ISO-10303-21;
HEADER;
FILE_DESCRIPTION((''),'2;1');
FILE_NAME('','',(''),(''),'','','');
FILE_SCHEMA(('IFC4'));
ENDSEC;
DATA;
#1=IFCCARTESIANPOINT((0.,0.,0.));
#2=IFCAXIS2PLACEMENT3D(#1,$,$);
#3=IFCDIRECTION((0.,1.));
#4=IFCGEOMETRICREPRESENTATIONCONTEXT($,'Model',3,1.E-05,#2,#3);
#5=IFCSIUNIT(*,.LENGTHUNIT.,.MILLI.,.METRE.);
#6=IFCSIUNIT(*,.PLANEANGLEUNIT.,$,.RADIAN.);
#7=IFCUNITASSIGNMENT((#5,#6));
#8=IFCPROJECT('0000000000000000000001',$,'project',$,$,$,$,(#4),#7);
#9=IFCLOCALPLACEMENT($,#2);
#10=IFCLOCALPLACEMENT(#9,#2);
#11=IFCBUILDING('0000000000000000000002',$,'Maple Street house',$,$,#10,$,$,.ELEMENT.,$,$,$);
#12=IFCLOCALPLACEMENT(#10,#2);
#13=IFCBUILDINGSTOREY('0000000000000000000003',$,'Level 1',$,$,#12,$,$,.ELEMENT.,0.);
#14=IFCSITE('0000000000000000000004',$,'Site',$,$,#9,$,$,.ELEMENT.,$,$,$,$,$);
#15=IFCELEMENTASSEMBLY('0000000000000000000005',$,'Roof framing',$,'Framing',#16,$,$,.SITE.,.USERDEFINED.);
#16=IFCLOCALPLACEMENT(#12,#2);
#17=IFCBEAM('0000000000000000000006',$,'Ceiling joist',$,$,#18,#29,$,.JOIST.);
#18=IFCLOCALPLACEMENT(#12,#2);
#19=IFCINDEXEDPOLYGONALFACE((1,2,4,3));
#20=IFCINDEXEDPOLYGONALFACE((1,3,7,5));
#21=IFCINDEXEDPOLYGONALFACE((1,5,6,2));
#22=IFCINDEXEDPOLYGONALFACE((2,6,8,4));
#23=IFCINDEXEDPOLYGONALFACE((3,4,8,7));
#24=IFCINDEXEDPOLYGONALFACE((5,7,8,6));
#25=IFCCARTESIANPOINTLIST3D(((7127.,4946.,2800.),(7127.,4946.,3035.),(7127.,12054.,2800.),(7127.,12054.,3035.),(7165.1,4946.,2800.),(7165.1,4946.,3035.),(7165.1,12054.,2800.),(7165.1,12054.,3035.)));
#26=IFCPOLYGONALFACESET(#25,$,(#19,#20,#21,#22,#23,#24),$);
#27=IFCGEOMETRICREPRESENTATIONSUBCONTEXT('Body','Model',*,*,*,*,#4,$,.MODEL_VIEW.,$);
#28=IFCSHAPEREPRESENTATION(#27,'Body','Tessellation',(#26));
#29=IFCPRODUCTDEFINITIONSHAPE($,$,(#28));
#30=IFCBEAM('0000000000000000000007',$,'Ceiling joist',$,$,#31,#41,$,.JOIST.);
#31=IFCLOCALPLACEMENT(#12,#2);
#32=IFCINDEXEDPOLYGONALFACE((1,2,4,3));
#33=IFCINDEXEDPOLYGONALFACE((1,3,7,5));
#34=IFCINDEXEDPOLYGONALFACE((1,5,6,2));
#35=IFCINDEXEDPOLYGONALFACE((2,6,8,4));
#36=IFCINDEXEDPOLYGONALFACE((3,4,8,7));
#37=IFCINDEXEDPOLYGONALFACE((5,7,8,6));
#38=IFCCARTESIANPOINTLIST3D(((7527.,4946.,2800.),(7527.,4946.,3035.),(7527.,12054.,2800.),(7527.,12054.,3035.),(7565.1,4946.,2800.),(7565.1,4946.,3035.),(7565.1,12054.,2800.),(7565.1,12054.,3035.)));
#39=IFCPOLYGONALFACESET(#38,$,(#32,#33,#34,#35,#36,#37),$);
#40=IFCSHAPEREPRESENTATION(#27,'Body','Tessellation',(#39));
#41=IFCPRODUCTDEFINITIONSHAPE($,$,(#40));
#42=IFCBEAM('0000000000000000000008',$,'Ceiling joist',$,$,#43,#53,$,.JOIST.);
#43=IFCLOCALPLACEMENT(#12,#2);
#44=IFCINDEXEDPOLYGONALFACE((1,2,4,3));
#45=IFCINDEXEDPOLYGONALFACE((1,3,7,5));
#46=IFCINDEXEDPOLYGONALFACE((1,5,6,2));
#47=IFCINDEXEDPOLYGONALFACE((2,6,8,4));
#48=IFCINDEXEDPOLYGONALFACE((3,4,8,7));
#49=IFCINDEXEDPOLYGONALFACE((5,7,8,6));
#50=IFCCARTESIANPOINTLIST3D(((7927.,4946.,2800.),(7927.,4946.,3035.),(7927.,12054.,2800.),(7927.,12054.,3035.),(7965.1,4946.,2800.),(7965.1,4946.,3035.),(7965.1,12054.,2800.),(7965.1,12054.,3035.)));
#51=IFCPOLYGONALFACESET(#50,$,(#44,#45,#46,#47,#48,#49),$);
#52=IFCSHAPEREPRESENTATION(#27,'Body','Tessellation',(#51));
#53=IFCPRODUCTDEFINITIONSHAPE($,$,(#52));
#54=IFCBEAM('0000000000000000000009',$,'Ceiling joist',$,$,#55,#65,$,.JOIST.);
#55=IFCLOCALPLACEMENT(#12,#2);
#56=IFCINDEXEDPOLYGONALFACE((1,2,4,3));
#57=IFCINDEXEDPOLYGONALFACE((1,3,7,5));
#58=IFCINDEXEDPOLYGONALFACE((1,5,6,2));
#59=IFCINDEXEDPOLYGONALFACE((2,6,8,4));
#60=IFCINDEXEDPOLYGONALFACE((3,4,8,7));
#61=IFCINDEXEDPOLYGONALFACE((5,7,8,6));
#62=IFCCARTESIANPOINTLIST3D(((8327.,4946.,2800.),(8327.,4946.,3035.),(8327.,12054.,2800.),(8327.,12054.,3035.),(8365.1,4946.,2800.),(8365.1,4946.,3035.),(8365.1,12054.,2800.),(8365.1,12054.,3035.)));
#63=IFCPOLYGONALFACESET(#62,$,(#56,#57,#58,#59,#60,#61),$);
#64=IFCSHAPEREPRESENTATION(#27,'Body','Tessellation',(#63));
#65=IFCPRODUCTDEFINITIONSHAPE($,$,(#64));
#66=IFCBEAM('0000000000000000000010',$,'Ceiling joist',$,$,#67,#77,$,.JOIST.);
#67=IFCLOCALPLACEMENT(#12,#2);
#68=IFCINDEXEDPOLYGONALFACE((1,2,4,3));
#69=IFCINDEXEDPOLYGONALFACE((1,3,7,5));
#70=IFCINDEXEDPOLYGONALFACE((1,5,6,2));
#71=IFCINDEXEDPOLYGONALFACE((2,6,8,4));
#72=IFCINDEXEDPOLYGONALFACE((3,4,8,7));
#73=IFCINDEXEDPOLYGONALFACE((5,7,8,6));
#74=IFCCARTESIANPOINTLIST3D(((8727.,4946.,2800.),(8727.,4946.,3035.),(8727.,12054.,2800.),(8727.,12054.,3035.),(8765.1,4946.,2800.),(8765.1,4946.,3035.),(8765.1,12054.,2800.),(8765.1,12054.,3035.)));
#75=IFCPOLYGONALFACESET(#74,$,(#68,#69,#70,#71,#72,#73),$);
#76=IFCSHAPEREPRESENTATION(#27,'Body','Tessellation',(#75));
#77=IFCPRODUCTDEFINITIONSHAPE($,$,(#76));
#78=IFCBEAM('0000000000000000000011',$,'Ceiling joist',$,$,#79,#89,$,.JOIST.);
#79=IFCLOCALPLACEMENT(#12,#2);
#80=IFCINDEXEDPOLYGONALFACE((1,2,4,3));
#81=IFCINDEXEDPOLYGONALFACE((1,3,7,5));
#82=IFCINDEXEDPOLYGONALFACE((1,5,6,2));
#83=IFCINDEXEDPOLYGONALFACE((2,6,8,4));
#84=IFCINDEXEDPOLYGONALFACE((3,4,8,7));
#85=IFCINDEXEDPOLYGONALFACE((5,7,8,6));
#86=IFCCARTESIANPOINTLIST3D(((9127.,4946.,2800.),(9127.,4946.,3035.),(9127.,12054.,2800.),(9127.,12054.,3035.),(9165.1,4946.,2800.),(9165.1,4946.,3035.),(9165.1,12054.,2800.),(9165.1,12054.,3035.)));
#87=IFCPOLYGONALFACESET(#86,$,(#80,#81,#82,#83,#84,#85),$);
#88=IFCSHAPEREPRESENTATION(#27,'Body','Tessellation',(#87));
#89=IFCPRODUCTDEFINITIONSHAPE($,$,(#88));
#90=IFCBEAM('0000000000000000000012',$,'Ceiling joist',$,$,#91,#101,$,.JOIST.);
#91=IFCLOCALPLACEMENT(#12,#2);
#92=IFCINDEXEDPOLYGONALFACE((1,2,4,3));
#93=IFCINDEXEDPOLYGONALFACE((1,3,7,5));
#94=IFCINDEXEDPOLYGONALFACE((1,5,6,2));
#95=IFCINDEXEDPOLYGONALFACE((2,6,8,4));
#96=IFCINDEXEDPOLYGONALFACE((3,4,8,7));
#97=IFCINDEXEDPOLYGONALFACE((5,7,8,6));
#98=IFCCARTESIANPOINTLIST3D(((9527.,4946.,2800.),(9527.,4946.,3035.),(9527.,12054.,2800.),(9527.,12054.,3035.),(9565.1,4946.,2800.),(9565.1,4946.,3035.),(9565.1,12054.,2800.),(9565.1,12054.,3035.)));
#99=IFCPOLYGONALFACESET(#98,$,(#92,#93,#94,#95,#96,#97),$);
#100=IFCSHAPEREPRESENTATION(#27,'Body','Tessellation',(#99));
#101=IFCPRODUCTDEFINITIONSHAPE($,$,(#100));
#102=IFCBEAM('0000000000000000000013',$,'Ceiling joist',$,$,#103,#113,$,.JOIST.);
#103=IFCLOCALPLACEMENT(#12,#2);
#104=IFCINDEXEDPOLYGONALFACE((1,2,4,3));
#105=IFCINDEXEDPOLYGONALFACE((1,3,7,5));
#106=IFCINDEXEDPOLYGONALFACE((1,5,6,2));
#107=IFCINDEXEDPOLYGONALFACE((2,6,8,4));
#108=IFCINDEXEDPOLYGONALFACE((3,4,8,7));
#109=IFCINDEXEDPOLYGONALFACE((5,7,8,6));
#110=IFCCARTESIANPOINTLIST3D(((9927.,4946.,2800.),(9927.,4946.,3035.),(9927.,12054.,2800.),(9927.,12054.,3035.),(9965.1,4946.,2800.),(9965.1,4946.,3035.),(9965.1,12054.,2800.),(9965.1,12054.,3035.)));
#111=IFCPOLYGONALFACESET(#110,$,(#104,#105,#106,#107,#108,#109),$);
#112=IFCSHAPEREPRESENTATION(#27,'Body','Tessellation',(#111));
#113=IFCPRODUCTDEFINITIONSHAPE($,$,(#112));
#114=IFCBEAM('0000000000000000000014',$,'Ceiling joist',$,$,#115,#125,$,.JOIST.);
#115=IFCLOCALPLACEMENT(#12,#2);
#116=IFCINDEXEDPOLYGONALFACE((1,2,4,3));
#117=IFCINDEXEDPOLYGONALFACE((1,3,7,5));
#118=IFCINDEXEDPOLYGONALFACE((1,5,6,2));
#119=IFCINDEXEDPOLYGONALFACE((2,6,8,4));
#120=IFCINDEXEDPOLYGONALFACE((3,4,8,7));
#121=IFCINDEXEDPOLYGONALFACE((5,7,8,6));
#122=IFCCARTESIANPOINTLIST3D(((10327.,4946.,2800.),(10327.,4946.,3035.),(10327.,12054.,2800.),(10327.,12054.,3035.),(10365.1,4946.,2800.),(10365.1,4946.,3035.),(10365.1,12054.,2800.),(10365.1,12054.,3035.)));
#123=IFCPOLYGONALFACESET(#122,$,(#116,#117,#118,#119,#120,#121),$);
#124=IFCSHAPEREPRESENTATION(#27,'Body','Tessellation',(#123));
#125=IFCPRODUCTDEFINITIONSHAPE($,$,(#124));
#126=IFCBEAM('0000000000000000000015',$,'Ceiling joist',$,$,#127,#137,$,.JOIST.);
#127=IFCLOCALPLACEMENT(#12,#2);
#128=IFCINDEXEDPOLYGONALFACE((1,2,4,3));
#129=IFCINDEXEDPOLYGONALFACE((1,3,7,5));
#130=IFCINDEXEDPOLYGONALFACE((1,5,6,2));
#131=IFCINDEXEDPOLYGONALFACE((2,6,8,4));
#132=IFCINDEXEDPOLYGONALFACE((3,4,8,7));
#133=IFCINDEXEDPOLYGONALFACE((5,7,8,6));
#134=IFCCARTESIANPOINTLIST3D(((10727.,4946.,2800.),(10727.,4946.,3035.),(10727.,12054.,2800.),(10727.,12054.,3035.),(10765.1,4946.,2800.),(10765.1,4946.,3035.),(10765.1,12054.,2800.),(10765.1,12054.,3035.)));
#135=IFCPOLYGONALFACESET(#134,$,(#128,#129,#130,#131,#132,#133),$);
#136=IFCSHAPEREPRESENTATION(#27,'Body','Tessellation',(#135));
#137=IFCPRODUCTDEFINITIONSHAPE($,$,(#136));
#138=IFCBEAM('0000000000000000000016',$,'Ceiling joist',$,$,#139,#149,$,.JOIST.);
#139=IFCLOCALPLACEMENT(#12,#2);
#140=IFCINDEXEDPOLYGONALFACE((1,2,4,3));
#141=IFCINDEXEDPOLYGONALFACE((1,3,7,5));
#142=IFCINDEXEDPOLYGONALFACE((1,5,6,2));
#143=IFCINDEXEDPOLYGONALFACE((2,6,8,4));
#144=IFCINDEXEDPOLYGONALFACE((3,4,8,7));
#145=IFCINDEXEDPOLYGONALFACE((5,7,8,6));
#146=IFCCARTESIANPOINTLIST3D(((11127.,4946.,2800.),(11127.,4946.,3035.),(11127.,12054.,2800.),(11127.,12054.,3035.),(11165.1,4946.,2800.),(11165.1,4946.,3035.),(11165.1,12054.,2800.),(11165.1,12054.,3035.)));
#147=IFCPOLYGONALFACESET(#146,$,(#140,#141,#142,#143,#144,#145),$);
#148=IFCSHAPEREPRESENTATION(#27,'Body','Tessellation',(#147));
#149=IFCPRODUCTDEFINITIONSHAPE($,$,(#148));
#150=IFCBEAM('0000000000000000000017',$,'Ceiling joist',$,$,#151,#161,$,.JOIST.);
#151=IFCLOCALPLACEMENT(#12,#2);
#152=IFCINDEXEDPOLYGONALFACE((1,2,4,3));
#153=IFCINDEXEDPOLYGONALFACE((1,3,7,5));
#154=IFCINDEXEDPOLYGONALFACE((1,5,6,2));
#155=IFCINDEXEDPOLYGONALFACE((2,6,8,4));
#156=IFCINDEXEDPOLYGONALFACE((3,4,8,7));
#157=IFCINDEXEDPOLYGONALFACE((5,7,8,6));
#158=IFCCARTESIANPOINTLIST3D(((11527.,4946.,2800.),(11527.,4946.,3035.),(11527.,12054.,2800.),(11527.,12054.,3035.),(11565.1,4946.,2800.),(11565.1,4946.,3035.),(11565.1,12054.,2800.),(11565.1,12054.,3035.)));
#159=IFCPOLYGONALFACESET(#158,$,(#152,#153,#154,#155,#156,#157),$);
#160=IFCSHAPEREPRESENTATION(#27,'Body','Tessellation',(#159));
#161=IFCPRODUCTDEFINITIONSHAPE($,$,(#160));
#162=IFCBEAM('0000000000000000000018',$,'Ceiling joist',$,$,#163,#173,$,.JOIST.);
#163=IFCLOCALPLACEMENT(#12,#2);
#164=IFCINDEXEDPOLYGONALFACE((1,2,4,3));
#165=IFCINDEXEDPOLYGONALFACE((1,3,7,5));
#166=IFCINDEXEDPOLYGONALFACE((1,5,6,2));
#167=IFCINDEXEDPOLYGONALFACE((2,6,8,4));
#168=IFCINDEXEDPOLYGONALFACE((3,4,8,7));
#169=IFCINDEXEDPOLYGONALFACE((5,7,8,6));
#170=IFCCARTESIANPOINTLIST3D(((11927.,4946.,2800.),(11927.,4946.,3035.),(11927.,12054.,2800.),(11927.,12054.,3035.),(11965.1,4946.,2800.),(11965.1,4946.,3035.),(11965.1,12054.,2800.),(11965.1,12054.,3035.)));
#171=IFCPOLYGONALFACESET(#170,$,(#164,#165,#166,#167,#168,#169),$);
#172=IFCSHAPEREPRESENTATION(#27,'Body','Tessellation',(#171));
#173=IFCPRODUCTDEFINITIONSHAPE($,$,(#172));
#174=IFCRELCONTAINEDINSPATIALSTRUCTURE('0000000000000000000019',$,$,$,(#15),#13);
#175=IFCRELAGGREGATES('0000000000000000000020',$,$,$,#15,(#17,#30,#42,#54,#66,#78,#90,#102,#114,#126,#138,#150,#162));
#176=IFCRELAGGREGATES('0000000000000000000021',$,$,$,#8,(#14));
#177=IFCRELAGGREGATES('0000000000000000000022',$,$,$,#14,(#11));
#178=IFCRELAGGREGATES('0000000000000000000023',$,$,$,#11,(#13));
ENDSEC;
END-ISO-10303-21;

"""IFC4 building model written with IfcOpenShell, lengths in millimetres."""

from ifc_helpers import new_model, si_unit, direction, frame, origin, origin_with_axes, place, context, subcontext, project, spatial, polyline, outline, extrude, element, aggregate, save


model = new_model("IFC4")

# Units and contexts
model_context = context("Model", 3, precision=1e-05, world=origin(), true_north=direction((0.0, 1.0)))
body_context = subcontext(model_context, "Body", "Model", "MODEL_VIEW")
ifc_project = project(units=[si_unit("LENGTHUNIT", "METRE", prefix="MILLI"), si_unit("PLANEANGLEUNIT", "RADIAN")], contexts=[model_context])

# Site, building, storey
site_placement = place(None, origin())
site = spatial("IfcSite", under=ifc_project, at=site_placement, Name="Site", CompositionType="ELEMENT")
building_placement = place(site_placement, origin())
building = spatial("IfcBuilding", under=site, at=building_placement, Name="Maple Street house", CompositionType="ELEMENT")
storey_placement = place(building_placement, origin())
storey = spatial("IfcBuildingStorey", under=building, at=storey_placement, Name="Level 1", CompositionType="ELEMENT", Elevation=0.0)

# Element assembly, beams
assembly_placement = place(storey_placement, origin_with_axes())
assembly = element("IfcElementAssembly", 1, at=assembly_placement, inside=storey, Name="Roof framing", ObjectType="Framing", AssemblyPlace="SITE", PredefinedType="USERDEFINED")
beam_1_placement = place(storey_placement, origin_with_axes())
beam_1 = element("IfcBeam", 2, at=beam_1_placement, Name="Ceiling joist", PredefinedType="JOIST", context=body_context, shape_type="SweptSolid", body=[
    extrude(outline(polyline([(0.0, 0.0), (38.1, 0.0), (38.1, 234.9), (0.0, 234.9), (0.0, 0.0)])), frame((7127.0, 12054.0, 2800.0), z_axis=(0.0, -1.0, 0.0), x_axis=(1.0, 0.0, 0.0)), (0.0, 0.0, 1.0), 7107.9),
])
beam_2_placement = place(storey_placement, origin_with_axes())
beam_2 = element("IfcBeam", 3, at=beam_2_placement, Name="Ceiling joist", PredefinedType="JOIST", context=body_context, shape_type="SweptSolid", body=[
    extrude(outline(polyline([(0.0, 0.0), (38.1, 0.0), (38.1, 234.9), (0.0, 234.9), (0.0, 0.0)])), frame((7527.0, 12054.0, 2800.0), z_axis=(0.0, -1.0, 0.0), x_axis=(1.0, 0.0, 0.0)), (0.0, 0.0, 1.0), 7107.9),
])
beam_3_placement = place(storey_placement, origin_with_axes())
beam_3 = element("IfcBeam", 4, at=beam_3_placement, Name="Ceiling joist", PredefinedType="JOIST", context=body_context, shape_type="SweptSolid", body=[
    extrude(outline(polyline([(0.0, 0.0), (38.1, 0.0), (38.1, 234.9), (0.0, 234.9), (0.0, 0.0)])), frame((7927.0, 12054.0, 2800.0), z_axis=(0.0, -1.0, 0.0), x_axis=(1.0, 0.0, 0.0)), (0.0, 0.0, 1.0), 7107.9),
])
beam_4_placement = place(storey_placement, origin_with_axes())
beam_4 = element("IfcBeam", 5, at=beam_4_placement, Name="Ceiling joist", PredefinedType="JOIST", context=body_context, shape_type="SweptSolid", body=[
    extrude(outline(polyline([(0.0, 0.0), (38.1, 0.0), (38.1, 234.9), (0.0, 234.9), (0.0, 0.0)])), frame((8327.0, 12054.0, 2800.0), z_axis=(0.0, -1.0, 0.0), x_axis=(1.0, 0.0, 0.0)), (0.0, 0.0, 1.0), 7107.9),
])
beam_5_placement = place(storey_placement, origin_with_axes())
beam_5 = element("IfcBeam", 6, at=beam_5_placement, Name="Ceiling joist", PredefinedType="JOIST", context=body_context, shape_type="SweptSolid", body=[
    extrude(outline(polyline([(0.0, 0.0), (38.1, 0.0), (38.1, 234.9), (0.0, 234.9), (0.0, 0.0)])), frame((8727.0, 12054.0, 2800.0), z_axis=(0.0, -1.0, 0.0), x_axis=(1.0, 0.0, 0.0)), (0.0, 0.0, 1.0), 7107.9),
])
beam_6_placement = place(storey_placement, origin_with_axes())
beam_6 = element("IfcBeam", 7, at=beam_6_placement, Name="Ceiling joist", PredefinedType="JOIST", context=body_context, shape_type="SweptSolid", body=[
    extrude(outline(polyline([(0.0, 0.0), (38.1, 0.0), (38.1, 234.9), (0.0, 234.9), (0.0, 0.0)])), frame((9127.0, 12054.0, 2800.0), z_axis=(0.0, -1.0, 0.0), x_axis=(1.0, 0.0, 0.0)), (0.0, 0.0, 1.0), 7107.9),
])
beam_7_placement = place(storey_placement, origin_with_axes())
beam_7 = element("IfcBeam", 8, at=beam_7_placement, Name="Ceiling joist", PredefinedType="JOIST", context=body_context, shape_type="SweptSolid", body=[
    extrude(outline(polyline([(0.0, 0.0), (38.1, 0.0), (38.1, 234.9), (0.0, 234.9), (0.0, 0.0)])), frame((9527.0, 12054.0, 2800.0), z_axis=(0.0, -1.0, 0.0), x_axis=(1.0, 0.0, 0.0)), (0.0, 0.0, 1.0), 7107.9),
])
beam_8_placement = place(storey_placement, origin_with_axes())
beam_8 = element("IfcBeam", 9, at=beam_8_placement, Name="Ceiling joist", PredefinedType="JOIST", context=body_context, shape_type="SweptSolid", body=[
    extrude(outline(polyline([(0.0, 0.0), (38.1, 0.0), (38.1, 234.9), (0.0, 234.9), (0.0, 0.0)])), frame((9927.0, 12054.0, 2800.0), z_axis=(0.0, -1.0, 0.0), x_axis=(1.0, 0.0, 0.0)), (0.0, 0.0, 1.0), 7107.9),
])
beam_9_placement = place(storey_placement, origin_with_axes())
beam_9 = element("IfcBeam", 10, at=beam_9_placement, Name="Ceiling joist", PredefinedType="JOIST", context=body_context, shape_type="SweptSolid", body=[
    extrude(outline(polyline([(0.0, 0.0), (38.1, 0.0), (38.1, 234.9), (0.0, 234.9), (0.0, 0.0)])), frame((10327.0, 12054.0, 2800.0), z_axis=(0.0, -1.0, 0.0), x_axis=(1.0, 0.0, 0.0)), (0.0, 0.0, 1.0), 7107.9),
])
beam_10_placement = place(storey_placement, origin_with_axes())
beam_10 = element("IfcBeam", 11, at=beam_10_placement, Name="Ceiling joist", PredefinedType="JOIST", context=body_context, shape_type="SweptSolid", body=[
    extrude(outline(polyline([(0.0, 0.0), (38.1, 0.0), (38.1, 234.9), (0.0, 234.9), (0.0, 0.0)])), frame((10727.0, 12054.0, 2800.0), z_axis=(0.0, -1.0, 0.0), x_axis=(1.0, 0.0, 0.0)), (0.0, 0.0, 1.0), 7107.9),
])
beam_11_placement = place(storey_placement, origin_with_axes())
beam_11 = element("IfcBeam", 12, at=beam_11_placement, Name="Ceiling joist", PredefinedType="JOIST", context=body_context, shape_type="SweptSolid", body=[
    extrude(outline(polyline([(0.0, 0.0), (38.1, 0.0), (38.1, 234.9), (0.0, 234.9), (0.0, 0.0)])), frame((11127.0, 12054.0, 2800.0), z_axis=(0.0, -1.0, 0.0), x_axis=(1.0, 0.0, 0.0)), (0.0, 0.0, 1.0), 7107.9),
])
beam_12_placement = place(storey_placement, origin_with_axes())
beam_12 = element("IfcBeam", 13, at=beam_12_placement, Name="Ceiling joist", PredefinedType="JOIST", context=body_context, shape_type="SweptSolid", body=[
    extrude(outline(polyline([(0.0, 0.0), (38.1, 0.0), (38.1, 234.9), (0.0, 234.9), (0.0, 0.0)])), frame((11527.0, 12054.0, 2800.0), z_axis=(0.0, -1.0, 0.0), x_axis=(1.0, 0.0, 0.0)), (0.0, 0.0, 1.0), 7107.9),
])
beam_13_placement = place(storey_placement, origin_with_axes())
beam_13 = element("IfcBeam", 14, at=beam_13_placement, Name="Ceiling joist", PredefinedType="JOIST", context=body_context, shape_type="SweptSolid", body=[
    extrude(outline(polyline([(0.0, 0.0), (38.1, 0.0), (38.1, 234.9), (0.0, 234.9), (0.0, 0.0)])), frame((11927.0, 12054.0, 2800.0), z_axis=(0.0, -1.0, 0.0), x_axis=(1.0, 0.0, 0.0)), (0.0, 0.0, 1.0), 7107.9),
])
aggregate(assembly, [beam_1, beam_2, beam_3, beam_4, beam_5, beam_6, beam_7, beam_8, beam_9, beam_10, beam_11, beam_12, beam_13])

save(model, "model.ifc")
